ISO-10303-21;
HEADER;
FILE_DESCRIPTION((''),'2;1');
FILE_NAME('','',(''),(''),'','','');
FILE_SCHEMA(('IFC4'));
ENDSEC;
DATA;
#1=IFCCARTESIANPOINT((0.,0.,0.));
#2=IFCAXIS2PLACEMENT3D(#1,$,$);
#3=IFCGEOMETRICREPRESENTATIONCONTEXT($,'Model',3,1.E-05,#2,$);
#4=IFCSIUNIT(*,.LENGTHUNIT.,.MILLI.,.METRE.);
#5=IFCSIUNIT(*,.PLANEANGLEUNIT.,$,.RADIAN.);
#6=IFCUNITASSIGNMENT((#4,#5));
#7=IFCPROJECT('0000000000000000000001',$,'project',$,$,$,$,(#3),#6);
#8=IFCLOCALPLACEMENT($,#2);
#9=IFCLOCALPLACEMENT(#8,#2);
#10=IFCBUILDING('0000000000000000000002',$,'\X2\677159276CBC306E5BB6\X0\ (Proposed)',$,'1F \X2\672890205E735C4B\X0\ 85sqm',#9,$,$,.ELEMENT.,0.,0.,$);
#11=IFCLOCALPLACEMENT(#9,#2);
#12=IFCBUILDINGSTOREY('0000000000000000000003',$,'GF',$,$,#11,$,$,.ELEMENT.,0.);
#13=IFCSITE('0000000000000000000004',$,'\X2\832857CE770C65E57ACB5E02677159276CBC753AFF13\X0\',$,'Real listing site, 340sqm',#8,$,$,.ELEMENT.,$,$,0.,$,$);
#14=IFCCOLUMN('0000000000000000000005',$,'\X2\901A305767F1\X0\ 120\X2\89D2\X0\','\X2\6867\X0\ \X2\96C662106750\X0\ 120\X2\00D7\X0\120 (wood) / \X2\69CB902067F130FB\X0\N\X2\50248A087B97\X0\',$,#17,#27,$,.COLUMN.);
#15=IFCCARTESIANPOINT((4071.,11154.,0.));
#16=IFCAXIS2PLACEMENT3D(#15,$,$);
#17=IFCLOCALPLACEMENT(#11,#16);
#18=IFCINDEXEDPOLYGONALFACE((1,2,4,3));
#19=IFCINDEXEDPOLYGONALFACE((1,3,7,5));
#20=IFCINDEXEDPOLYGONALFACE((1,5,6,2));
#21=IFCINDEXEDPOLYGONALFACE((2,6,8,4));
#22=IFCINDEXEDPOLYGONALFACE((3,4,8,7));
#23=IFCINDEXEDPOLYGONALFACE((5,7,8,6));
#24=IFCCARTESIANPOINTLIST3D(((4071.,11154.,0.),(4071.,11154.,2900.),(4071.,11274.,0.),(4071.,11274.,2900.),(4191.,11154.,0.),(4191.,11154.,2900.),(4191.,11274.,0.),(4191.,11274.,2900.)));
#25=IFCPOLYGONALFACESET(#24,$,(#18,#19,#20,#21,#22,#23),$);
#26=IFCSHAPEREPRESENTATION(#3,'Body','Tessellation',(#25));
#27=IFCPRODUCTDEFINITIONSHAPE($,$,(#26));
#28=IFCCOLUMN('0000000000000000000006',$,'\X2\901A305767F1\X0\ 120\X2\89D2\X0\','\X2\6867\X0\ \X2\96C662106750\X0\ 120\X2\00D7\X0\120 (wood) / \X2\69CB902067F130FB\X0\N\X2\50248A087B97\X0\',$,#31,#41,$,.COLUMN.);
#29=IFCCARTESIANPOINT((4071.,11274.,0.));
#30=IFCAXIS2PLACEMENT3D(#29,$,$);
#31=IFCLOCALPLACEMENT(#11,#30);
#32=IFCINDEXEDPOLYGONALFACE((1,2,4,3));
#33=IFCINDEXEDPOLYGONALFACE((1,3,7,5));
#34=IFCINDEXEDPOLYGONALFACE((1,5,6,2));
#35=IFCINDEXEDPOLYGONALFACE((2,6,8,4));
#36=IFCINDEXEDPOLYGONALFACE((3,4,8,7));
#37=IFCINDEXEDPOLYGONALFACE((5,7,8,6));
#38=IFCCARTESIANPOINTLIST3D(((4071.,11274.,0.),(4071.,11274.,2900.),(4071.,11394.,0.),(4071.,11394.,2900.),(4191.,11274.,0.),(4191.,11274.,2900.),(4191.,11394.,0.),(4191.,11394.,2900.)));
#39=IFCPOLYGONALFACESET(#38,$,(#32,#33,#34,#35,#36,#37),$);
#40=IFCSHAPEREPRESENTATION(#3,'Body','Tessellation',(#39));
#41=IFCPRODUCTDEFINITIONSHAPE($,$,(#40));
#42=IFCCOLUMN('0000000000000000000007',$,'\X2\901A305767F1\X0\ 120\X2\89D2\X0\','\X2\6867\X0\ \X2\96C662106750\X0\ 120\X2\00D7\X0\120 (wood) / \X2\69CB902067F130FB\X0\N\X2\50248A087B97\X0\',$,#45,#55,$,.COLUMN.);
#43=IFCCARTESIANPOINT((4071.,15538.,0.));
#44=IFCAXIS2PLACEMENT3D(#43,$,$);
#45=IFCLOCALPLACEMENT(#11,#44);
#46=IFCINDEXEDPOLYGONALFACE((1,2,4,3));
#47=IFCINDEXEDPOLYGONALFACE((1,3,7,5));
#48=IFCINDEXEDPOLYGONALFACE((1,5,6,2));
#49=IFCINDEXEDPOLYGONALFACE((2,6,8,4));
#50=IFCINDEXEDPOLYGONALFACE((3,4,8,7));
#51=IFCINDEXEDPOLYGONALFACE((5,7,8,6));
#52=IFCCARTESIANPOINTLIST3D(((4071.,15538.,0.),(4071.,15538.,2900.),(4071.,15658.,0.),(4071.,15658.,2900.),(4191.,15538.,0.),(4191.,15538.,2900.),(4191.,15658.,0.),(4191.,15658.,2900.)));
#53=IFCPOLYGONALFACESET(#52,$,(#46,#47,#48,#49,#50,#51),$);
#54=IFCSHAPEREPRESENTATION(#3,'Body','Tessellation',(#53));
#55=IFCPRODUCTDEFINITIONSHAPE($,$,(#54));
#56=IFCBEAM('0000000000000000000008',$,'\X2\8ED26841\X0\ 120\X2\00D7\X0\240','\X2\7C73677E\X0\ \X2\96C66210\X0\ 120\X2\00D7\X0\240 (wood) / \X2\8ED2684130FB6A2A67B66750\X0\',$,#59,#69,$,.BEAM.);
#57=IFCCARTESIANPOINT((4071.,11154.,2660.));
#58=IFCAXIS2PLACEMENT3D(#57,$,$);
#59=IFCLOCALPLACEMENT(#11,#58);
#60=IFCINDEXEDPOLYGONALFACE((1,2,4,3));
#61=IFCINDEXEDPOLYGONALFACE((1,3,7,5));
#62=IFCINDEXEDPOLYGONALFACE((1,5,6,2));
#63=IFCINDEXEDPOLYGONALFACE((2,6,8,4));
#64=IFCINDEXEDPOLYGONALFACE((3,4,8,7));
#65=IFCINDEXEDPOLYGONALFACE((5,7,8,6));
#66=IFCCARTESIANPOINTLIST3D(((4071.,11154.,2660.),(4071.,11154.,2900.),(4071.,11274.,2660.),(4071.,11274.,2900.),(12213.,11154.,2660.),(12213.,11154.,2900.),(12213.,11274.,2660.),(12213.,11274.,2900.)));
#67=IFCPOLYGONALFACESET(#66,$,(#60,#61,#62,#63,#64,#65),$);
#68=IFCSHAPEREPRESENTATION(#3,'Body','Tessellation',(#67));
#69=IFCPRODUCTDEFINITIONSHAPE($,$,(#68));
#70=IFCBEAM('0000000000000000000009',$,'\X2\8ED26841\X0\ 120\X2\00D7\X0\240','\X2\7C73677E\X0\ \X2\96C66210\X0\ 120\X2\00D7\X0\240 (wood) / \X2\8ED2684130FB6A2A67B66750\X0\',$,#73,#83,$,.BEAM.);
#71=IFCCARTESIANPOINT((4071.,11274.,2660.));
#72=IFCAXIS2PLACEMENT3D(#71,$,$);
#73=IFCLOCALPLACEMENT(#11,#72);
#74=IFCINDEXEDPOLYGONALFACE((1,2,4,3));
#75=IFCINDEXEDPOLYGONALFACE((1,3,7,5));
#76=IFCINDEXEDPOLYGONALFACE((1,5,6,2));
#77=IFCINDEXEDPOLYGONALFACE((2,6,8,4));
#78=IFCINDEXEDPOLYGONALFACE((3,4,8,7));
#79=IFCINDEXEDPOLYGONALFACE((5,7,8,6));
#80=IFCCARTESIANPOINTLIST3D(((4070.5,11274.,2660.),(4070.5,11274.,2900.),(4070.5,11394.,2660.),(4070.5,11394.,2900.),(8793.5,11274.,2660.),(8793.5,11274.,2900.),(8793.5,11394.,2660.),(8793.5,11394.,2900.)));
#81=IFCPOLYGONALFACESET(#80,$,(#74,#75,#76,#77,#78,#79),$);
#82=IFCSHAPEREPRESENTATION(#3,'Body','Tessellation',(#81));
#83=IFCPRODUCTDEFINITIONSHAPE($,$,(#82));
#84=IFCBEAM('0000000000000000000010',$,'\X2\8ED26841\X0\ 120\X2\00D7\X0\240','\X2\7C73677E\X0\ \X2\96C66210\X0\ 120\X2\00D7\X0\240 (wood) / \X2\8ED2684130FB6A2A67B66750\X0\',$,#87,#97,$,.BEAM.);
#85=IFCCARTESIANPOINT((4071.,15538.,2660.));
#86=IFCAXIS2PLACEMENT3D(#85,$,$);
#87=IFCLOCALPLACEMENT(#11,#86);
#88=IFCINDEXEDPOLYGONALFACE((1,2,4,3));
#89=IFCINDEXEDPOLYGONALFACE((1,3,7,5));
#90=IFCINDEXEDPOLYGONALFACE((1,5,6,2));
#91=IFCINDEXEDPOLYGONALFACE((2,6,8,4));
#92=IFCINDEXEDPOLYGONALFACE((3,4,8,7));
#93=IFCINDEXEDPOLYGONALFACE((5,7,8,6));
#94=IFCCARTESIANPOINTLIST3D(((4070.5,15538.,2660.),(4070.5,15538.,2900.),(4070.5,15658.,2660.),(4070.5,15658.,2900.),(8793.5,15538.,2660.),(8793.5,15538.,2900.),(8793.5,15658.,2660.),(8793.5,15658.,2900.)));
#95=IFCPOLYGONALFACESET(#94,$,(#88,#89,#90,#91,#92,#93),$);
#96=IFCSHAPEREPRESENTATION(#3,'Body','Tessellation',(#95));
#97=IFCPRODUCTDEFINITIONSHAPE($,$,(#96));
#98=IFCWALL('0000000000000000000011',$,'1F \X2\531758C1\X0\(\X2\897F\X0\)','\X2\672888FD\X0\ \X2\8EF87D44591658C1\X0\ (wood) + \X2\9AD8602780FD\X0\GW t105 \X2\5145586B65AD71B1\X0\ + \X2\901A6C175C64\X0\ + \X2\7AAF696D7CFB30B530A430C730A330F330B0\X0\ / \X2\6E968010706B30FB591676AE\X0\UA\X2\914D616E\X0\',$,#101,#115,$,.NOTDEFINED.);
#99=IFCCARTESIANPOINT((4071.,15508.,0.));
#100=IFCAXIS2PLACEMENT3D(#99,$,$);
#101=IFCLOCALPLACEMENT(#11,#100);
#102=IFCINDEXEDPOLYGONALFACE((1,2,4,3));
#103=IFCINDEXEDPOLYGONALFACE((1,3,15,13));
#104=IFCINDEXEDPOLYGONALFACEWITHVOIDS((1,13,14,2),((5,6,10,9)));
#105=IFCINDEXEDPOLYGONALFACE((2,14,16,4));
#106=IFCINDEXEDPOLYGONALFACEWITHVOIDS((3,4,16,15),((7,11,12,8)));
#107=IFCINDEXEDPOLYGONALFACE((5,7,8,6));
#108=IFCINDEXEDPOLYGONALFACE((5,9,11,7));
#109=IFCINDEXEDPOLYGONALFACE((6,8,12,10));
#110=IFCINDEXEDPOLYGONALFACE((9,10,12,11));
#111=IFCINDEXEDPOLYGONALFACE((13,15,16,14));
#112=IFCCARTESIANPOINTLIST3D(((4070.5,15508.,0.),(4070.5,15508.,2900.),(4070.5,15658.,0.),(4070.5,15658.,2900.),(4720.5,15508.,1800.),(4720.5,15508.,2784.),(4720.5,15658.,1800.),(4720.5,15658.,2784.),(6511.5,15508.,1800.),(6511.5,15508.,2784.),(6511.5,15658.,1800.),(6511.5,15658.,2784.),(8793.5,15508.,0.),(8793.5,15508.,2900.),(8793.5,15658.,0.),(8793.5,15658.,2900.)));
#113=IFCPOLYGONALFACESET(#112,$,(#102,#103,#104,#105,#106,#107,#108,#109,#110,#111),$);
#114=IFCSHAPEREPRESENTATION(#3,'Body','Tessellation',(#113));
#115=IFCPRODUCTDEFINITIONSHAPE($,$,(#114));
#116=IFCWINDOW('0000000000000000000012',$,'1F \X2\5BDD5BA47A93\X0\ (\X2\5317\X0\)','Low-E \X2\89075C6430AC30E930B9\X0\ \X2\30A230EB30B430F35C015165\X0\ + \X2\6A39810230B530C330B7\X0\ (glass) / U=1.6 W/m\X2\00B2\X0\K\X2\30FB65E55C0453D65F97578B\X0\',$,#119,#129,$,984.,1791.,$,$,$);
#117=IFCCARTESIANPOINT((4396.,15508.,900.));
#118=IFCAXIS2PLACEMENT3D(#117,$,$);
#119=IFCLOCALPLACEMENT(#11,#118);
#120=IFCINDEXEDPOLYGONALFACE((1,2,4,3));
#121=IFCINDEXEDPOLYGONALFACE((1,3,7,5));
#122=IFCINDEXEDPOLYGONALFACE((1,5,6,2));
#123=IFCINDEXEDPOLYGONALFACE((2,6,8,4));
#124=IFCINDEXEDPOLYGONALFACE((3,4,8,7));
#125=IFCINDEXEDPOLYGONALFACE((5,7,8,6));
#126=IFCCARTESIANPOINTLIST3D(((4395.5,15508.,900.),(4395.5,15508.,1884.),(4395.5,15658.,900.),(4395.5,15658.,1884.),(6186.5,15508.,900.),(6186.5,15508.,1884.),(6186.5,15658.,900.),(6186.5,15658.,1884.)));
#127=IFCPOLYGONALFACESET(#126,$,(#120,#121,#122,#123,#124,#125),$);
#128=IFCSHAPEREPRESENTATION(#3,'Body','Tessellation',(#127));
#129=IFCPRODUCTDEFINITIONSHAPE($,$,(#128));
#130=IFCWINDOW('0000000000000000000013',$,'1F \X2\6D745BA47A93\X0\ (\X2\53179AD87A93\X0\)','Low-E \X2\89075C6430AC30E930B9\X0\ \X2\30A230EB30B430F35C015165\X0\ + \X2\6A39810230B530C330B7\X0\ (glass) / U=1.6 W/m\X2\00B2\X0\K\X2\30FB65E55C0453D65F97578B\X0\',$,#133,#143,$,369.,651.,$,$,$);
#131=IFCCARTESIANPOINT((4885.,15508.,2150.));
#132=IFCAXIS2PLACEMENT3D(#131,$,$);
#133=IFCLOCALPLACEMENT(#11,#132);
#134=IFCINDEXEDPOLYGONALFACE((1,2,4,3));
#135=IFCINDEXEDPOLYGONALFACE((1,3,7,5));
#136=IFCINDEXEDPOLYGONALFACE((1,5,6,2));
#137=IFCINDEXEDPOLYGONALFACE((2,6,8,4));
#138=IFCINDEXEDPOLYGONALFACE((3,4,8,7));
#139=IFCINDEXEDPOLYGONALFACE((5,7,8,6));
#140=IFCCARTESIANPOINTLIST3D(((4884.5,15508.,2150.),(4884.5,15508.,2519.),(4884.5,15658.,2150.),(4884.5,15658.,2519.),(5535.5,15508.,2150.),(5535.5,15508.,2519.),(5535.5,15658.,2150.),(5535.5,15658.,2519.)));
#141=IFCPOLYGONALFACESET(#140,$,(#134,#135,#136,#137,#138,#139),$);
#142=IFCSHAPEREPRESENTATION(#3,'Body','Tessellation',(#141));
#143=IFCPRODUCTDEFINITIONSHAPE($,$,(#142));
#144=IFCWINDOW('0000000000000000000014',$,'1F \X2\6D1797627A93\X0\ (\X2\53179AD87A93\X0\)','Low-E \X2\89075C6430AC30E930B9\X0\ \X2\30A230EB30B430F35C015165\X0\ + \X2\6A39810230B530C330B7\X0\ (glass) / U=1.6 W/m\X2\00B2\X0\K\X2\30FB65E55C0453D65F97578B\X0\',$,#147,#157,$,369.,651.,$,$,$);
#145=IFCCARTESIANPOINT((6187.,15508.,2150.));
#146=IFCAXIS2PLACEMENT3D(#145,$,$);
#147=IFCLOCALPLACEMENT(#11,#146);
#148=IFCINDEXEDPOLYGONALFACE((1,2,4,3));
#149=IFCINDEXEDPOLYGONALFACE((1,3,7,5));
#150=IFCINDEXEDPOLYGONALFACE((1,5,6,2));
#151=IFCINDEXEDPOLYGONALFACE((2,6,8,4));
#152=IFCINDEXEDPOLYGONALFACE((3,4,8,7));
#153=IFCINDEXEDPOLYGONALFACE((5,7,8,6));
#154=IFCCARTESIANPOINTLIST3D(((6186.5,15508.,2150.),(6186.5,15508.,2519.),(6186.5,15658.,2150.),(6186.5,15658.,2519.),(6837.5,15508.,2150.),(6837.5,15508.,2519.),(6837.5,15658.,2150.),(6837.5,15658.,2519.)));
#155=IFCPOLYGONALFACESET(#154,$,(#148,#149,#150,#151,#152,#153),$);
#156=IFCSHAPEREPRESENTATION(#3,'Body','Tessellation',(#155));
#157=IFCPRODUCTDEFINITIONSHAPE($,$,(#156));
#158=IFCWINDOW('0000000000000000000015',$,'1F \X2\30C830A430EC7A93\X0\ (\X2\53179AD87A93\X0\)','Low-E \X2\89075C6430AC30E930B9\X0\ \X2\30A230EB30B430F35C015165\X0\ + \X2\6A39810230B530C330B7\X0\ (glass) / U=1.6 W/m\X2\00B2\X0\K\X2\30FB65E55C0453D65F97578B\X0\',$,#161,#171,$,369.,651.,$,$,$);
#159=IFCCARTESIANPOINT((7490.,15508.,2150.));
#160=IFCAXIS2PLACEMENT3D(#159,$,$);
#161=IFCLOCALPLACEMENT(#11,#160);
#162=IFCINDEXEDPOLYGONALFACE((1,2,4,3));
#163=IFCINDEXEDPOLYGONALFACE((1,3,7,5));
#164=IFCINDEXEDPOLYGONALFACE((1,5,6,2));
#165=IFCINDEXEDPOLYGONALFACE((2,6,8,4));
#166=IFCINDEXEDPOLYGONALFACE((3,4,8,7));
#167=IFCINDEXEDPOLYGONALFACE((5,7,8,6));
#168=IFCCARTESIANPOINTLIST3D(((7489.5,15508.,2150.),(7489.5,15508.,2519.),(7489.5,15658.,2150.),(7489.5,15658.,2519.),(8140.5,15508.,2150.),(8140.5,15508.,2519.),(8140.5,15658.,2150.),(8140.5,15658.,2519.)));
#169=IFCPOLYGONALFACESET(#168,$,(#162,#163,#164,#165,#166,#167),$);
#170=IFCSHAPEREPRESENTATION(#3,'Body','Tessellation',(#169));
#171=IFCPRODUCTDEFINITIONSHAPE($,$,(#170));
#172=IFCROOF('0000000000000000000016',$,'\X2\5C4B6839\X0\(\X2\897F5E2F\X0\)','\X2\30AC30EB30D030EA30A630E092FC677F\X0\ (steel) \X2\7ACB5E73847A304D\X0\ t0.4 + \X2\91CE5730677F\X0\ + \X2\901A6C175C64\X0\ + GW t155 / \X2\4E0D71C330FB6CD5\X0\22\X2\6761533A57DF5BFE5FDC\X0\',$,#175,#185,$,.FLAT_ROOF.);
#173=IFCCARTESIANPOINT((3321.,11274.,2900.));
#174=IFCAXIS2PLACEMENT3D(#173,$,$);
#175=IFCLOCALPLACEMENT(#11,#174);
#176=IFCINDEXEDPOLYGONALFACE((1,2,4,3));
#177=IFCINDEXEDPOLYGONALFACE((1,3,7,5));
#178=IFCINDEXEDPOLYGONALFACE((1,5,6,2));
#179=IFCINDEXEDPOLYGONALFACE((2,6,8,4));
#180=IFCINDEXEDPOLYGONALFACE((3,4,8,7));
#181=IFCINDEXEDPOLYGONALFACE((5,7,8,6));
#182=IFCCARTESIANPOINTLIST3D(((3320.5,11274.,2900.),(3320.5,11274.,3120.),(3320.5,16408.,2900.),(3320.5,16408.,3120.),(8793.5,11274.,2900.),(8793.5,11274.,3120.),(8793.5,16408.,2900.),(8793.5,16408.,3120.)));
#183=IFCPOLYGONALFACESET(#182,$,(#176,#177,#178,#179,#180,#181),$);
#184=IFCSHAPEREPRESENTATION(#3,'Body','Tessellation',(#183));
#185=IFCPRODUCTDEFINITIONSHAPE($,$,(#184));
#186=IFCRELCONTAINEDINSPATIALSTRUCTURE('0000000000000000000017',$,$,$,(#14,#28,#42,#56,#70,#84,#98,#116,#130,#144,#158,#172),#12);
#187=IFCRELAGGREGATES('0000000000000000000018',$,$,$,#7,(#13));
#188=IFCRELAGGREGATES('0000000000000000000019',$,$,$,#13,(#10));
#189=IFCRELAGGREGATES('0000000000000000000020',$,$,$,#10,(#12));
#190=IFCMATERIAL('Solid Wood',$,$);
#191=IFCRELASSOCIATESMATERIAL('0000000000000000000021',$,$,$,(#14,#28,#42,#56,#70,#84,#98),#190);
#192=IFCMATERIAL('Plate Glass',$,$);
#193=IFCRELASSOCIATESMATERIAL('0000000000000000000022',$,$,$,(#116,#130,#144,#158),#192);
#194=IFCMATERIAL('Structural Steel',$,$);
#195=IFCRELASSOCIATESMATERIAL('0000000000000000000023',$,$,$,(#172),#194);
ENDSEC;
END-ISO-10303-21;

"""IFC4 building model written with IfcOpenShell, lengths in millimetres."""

from ifc_helpers import new_model, si_unit, frame, frame_2d, origin, place, context, project, spatial, rectangle, extrude, material, element, fill, save


model = new_model("IFC4")

# Units and contexts
model_context = context("Model", 3, precision=1e-05, world=origin())
ifc_project = project(units=[si_unit("LENGTHUNIT", "METRE", prefix="MILLI"), si_unit("PLANEANGLEUNIT", "RADIAN")], contexts=[model_context])

# Site, building, storey
site_placement = place(None, origin())
site = spatial("IfcSite", under=ifc_project, at=site_placement, Name="茨城県日立市東大沼町３", ObjectType="Real listing site, 340sqm", CompositionType="ELEMENT", RefElevation=0.0)
building_placement = place(site_placement, origin())
building = spatial("IfcBuilding", under=site, at=building_placement, Name="東大沼の家 (Proposed)", ObjectType="1F 木造平屋 85sqm", CompositionType="ELEMENT", ElevationOfRefHeight=0.0, ElevationOfTerrain=0.0)
storey_placement = place(building_placement, origin())
storey = spatial("IfcBuildingStorey", under=building, at=storey_placement, Name="GF", CompositionType="ELEMENT", Elevation=0.0)

# Columns
ifc_material_1 = material(Name="Solid Wood")
column_1_placement = place(storey_placement, frame((4071.0, 11154.0, 0.0)))
element("IfcColumn", 1, at=column_1_placement, inside=storey, material=ifc_material_1, Name="通し柱 120角", Description="桧 集成材 120×120 (wood) / 構造柱・N値計算", PredefinedType="COLUMN", context=model_context, shape_type="SweptSolid", body=[
    extrude(rectangle(XDim=120.0, YDim=120.0, at=frame_2d((60.0, 60.0))), frame((4071.0, 11154.0, 0.0)), (0.0, 0.0, 1.0), 2900.0),
])
column_2_placement = place(storey_placement, frame((4071.0, 11274.0, 0.0)))
element("IfcColumn", 2, at=column_2_placement, inside=storey, material=ifc_material_1, Name="通し柱 120角", Description="桧 集成材 120×120 (wood) / 構造柱・N値計算", PredefinedType="COLUMN", context=model_context, shape_type="SweptSolid", body=[
    extrude(rectangle(XDim=120.0, YDim=120.0, at=frame_2d((60.0, 60.0))), frame((4071.0, 11274.0, 0.0)), (0.0, 0.0, 1.0), 2900.0),
])
column_3_placement = place(storey_placement, frame((4071.0, 15538.0, 0.0)))
element("IfcColumn", 3, at=column_3_placement, inside=storey, material=ifc_material_1, Name="通し柱 120角", Description="桧 集成材 120×120 (wood) / 構造柱・N値計算", PredefinedType="COLUMN", context=model_context, shape_type="SweptSolid", body=[
    extrude(rectangle(XDim=120.0, YDim=120.0, at=frame_2d((60.0, 60.0))), frame((4071.0, 15538.0, 0.0)), (0.0, 0.0, 1.0), 2900.0),
])

# Beams
beam_1_placement = place(storey_placement, frame((4071.0, 11154.0, 2660.0)))
element("IfcBeam", 4, at=beam_1_placement, inside=storey, material=ifc_material_1, Name="軒桁 120×240", Description="米松 集成 120×240 (wood) / 軒桁・横架材", PredefinedType="BEAM", context=model_context, shape_type="SweptSolid", body=[
    extrude(rectangle(XDim=8142.0, YDim=120.0, at=frame_2d((4071.0, 60.0))), frame((4071.0, 11154.0, 2660.0)), (0.0, 0.0, 1.0), 240.0),
])
beam_2_placement = place(storey_placement, frame((4071.0, 11274.0, 2660.0)))
element("IfcBeam", 5, at=beam_2_placement, inside=storey, material=ifc_material_1, Name="軒桁 120×240", Description="米松 集成 120×240 (wood) / 軒桁・横架材", PredefinedType="BEAM", context=model_context, shape_type="SweptSolid", body=[
    extrude(rectangle(XDim=4723.0, YDim=120.0, at=frame_2d((2361.0, 60.0))), frame((4071.0, 11274.0, 2660.0)), (0.0, 0.0, 1.0), 240.0),
])
beam_3_placement = place(storey_placement, frame((4071.0, 15538.0, 2660.0)))
element("IfcBeam", 6, at=beam_3_placement, inside=storey, material=ifc_material_1, Name="軒桁 120×240", Description="米松 集成 120×240 (wood) / 軒桁・横架材", PredefinedType="BEAM", context=model_context, shape_type="SweptSolid", body=[
    extrude(rectangle(XDim=4723.0, YDim=120.0, at=frame_2d((2361.0, 60.0))), frame((4071.0, 15538.0, 2660.0)), (0.0, 0.0, 1.0), 240.0),
])

# Wall, openings, windows
wall_1_placement = place(storey_placement, frame((4071.0, 15508.0, 0.0)))
wall_1 = element("IfcWall", 7, at=wall_1_placement, inside=storey, material=ifc_material_1, Name="1F 北壁(西)", Description="木製 軸組外壁 (wood) + 高性能GW t105 充填断熱 + 通気層 + 窯業系サイディング / 準耐火・外皮UA配慮", PredefinedType="NOTDEFINED", context=model_context, shape_type="SweptSolid", body=[
    extrude(rectangle(XDim=4723.0, YDim=150.0, at=frame_2d((2361.0, 75.0))), frame((4071.0, 15508.0, 0.0)), (0.0, 0.0, 1.0), 2900.0),
])
opening_1_placement = place(storey_placement, frame((4396.0, 15508.0, 900.0)))
opening_1 = element("IfcOpeningElement", 8, at=opening_1_placement, cuts=wall_1, PredefinedType="NOTDEFINED", context=model_context, shape_type="SweptSolid", body=[
    extrude(rectangle(XDim=1791.0, YDim=150.0, at=frame_2d((895.0, 75.0))), frame((4396.0, 15508.0, 900.0)), (0.0, 0.0, 1.0), 984.0),
])
opening_2_placement = place(storey_placement, frame((4885.0, 15508.0, 2150.0)))
opening_2 = element("IfcOpeningElement", 9, at=opening_2_placement, cuts=wall_1, PredefinedType="NOTDEFINED", context=model_context, shape_type="SweptSolid", body=[
    extrude(rectangle(XDim=651.0, YDim=150.0, at=frame_2d((325.0, 75.0))), frame((4885.0, 15508.0, 2150.0)), (0.0, 0.0, 1.0), 369.0),
])
opening_3_placement = place(storey_placement, frame((6187.0, 15508.0, 2150.0)))
opening_3 = element("IfcOpeningElement", 10, at=opening_3_placement, cuts=wall_1, PredefinedType="NOTDEFINED", context=model_context, shape_type="SweptSolid", body=[
    extrude(rectangle(XDim=651.0, YDim=150.0, at=frame_2d((325.0, 75.0))), frame((6187.0, 15508.0, 2150.0)), (0.0, 0.0, 1.0), 369.0),
])
opening_4_placement = place(storey_placement, frame((7490.0, 15508.0, 2150.0)))
opening_4 = element("IfcOpeningElement", 11, at=opening_4_placement, cuts=wall_1, PredefinedType="NOTDEFINED", context=model_context, shape_type="SweptSolid", body=[
    extrude(rectangle(XDim=651.0, YDim=150.0, at=frame_2d((325.0, 75.0))), frame((7490.0, 15508.0, 2150.0)), (0.0, 0.0, 1.0), 369.0),
])
ifc_material_2 = material(Name="Plate Glass")
window_1_placement = place(storey_placement, frame((4396.0, 15508.0, 900.0)))
window_1 = element("IfcWindow", 12, at=window_1_placement, inside=storey, material=ifc_material_2, Name="1F 寝室窓 (北)", Description="Low-E 複層ガラス アルゴン封入 + 樹脂サッシ (glass) / U=1.6 W/m²K・日射取得型", OverallHeight=984.0, OverallWidth=1791.0, context=model_context, shape_type="SweptSolid", body=[
    extrude(rectangle(XDim=1791.0, YDim=150.0, at=frame_2d((895.0, 75.0))), frame((4396.0, 15508.0, 900.0)), (0.0, 0.0, 1.0), 984.0),
])
fill(opening_1, window_1)
window_2_placement = place(storey_placement, frame((4885.0, 15508.0, 2150.0)))
window_2 = element("IfcWindow", 13, at=window_2_placement, inside=storey, material=ifc_material_2, Name="1F 浴室窓 (北高窓)", Description="Low-E 複層ガラス アルゴン封入 + 樹脂サッシ (glass) / U=1.6 W/m²K・日射取得型", OverallHeight=369.0, OverallWidth=651.0, context=model_context, shape_type="SweptSolid", body=[
    extrude(rectangle(XDim=651.0, YDim=150.0, at=frame_2d((325.0, 75.0))), frame((4885.0, 15508.0, 2150.0)), (0.0, 0.0, 1.0), 369.0),
])
fill(opening_2, window_2)
window_3_placement = place(storey_placement, frame((6187.0, 15508.0, 2150.0)))
window_3 = element("IfcWindow", 14, at=window_3_placement, inside=storey, material=ifc_material_2, Name="1F 洗面窓 (北高窓)", Description="Low-E 複層ガラス アルゴン封入 + 樹脂サッシ (glass) / U=1.6 W/m²K・日射取得型", OverallHeight=369.0, OverallWidth=651.0, context=model_context, shape_type="SweptSolid", body=[
    extrude(rectangle(XDim=651.0, YDim=150.0, at=frame_2d((325.0, 75.0))), frame((6187.0, 15508.0, 2150.0)), (0.0, 0.0, 1.0), 369.0),
])
fill(opening_3, window_3)
window_4_placement = place(storey_placement, frame((7490.0, 15508.0, 2150.0)))
window_4 = element("IfcWindow", 15, at=window_4_placement, inside=storey, material=ifc_material_2, Name="1F トイレ窓 (北高窓)", Description="Low-E 複層ガラス アルゴン封入 + 樹脂サッシ (glass) / U=1.6 W/m²K・日射取得型", OverallHeight=369.0, OverallWidth=651.0, context=model_context, shape_type="SweptSolid", body=[
    extrude(rectangle(XDim=651.0, YDim=150.0, at=frame_2d((325.0, 75.0))), frame((7490.0, 15508.0, 2150.0)), (0.0, 0.0, 1.0), 369.0),
])
fill(opening_4, window_4)

# Roof
ifc_material_3 = material(Name="Structural Steel")
roof_placement = place(storey_placement, frame((3321.0, 11274.0, 2900.0)))
element("IfcRoof", 16, at=roof_placement, inside=storey, material=ifc_material_3, Name="屋根(西帯)", Description="ガルバリウム鋼板 (steel) 立平葺き t0.4 + 野地板 + 通気層 + GW t155 / 不燃・法22条区域対応", PredefinedType="FLAT_ROOF", context=model_context, shape_type="SweptSolid", body=[
    extrude(rectangle(XDim=5473.0, YDim=5134.0, at=frame_2d((2736.0, 2567.0))), frame((3321.0, 11274.0, 2900.0)), (0.0, 0.0, 1.0), 220.0),
])

save(model, "model.ifc")
